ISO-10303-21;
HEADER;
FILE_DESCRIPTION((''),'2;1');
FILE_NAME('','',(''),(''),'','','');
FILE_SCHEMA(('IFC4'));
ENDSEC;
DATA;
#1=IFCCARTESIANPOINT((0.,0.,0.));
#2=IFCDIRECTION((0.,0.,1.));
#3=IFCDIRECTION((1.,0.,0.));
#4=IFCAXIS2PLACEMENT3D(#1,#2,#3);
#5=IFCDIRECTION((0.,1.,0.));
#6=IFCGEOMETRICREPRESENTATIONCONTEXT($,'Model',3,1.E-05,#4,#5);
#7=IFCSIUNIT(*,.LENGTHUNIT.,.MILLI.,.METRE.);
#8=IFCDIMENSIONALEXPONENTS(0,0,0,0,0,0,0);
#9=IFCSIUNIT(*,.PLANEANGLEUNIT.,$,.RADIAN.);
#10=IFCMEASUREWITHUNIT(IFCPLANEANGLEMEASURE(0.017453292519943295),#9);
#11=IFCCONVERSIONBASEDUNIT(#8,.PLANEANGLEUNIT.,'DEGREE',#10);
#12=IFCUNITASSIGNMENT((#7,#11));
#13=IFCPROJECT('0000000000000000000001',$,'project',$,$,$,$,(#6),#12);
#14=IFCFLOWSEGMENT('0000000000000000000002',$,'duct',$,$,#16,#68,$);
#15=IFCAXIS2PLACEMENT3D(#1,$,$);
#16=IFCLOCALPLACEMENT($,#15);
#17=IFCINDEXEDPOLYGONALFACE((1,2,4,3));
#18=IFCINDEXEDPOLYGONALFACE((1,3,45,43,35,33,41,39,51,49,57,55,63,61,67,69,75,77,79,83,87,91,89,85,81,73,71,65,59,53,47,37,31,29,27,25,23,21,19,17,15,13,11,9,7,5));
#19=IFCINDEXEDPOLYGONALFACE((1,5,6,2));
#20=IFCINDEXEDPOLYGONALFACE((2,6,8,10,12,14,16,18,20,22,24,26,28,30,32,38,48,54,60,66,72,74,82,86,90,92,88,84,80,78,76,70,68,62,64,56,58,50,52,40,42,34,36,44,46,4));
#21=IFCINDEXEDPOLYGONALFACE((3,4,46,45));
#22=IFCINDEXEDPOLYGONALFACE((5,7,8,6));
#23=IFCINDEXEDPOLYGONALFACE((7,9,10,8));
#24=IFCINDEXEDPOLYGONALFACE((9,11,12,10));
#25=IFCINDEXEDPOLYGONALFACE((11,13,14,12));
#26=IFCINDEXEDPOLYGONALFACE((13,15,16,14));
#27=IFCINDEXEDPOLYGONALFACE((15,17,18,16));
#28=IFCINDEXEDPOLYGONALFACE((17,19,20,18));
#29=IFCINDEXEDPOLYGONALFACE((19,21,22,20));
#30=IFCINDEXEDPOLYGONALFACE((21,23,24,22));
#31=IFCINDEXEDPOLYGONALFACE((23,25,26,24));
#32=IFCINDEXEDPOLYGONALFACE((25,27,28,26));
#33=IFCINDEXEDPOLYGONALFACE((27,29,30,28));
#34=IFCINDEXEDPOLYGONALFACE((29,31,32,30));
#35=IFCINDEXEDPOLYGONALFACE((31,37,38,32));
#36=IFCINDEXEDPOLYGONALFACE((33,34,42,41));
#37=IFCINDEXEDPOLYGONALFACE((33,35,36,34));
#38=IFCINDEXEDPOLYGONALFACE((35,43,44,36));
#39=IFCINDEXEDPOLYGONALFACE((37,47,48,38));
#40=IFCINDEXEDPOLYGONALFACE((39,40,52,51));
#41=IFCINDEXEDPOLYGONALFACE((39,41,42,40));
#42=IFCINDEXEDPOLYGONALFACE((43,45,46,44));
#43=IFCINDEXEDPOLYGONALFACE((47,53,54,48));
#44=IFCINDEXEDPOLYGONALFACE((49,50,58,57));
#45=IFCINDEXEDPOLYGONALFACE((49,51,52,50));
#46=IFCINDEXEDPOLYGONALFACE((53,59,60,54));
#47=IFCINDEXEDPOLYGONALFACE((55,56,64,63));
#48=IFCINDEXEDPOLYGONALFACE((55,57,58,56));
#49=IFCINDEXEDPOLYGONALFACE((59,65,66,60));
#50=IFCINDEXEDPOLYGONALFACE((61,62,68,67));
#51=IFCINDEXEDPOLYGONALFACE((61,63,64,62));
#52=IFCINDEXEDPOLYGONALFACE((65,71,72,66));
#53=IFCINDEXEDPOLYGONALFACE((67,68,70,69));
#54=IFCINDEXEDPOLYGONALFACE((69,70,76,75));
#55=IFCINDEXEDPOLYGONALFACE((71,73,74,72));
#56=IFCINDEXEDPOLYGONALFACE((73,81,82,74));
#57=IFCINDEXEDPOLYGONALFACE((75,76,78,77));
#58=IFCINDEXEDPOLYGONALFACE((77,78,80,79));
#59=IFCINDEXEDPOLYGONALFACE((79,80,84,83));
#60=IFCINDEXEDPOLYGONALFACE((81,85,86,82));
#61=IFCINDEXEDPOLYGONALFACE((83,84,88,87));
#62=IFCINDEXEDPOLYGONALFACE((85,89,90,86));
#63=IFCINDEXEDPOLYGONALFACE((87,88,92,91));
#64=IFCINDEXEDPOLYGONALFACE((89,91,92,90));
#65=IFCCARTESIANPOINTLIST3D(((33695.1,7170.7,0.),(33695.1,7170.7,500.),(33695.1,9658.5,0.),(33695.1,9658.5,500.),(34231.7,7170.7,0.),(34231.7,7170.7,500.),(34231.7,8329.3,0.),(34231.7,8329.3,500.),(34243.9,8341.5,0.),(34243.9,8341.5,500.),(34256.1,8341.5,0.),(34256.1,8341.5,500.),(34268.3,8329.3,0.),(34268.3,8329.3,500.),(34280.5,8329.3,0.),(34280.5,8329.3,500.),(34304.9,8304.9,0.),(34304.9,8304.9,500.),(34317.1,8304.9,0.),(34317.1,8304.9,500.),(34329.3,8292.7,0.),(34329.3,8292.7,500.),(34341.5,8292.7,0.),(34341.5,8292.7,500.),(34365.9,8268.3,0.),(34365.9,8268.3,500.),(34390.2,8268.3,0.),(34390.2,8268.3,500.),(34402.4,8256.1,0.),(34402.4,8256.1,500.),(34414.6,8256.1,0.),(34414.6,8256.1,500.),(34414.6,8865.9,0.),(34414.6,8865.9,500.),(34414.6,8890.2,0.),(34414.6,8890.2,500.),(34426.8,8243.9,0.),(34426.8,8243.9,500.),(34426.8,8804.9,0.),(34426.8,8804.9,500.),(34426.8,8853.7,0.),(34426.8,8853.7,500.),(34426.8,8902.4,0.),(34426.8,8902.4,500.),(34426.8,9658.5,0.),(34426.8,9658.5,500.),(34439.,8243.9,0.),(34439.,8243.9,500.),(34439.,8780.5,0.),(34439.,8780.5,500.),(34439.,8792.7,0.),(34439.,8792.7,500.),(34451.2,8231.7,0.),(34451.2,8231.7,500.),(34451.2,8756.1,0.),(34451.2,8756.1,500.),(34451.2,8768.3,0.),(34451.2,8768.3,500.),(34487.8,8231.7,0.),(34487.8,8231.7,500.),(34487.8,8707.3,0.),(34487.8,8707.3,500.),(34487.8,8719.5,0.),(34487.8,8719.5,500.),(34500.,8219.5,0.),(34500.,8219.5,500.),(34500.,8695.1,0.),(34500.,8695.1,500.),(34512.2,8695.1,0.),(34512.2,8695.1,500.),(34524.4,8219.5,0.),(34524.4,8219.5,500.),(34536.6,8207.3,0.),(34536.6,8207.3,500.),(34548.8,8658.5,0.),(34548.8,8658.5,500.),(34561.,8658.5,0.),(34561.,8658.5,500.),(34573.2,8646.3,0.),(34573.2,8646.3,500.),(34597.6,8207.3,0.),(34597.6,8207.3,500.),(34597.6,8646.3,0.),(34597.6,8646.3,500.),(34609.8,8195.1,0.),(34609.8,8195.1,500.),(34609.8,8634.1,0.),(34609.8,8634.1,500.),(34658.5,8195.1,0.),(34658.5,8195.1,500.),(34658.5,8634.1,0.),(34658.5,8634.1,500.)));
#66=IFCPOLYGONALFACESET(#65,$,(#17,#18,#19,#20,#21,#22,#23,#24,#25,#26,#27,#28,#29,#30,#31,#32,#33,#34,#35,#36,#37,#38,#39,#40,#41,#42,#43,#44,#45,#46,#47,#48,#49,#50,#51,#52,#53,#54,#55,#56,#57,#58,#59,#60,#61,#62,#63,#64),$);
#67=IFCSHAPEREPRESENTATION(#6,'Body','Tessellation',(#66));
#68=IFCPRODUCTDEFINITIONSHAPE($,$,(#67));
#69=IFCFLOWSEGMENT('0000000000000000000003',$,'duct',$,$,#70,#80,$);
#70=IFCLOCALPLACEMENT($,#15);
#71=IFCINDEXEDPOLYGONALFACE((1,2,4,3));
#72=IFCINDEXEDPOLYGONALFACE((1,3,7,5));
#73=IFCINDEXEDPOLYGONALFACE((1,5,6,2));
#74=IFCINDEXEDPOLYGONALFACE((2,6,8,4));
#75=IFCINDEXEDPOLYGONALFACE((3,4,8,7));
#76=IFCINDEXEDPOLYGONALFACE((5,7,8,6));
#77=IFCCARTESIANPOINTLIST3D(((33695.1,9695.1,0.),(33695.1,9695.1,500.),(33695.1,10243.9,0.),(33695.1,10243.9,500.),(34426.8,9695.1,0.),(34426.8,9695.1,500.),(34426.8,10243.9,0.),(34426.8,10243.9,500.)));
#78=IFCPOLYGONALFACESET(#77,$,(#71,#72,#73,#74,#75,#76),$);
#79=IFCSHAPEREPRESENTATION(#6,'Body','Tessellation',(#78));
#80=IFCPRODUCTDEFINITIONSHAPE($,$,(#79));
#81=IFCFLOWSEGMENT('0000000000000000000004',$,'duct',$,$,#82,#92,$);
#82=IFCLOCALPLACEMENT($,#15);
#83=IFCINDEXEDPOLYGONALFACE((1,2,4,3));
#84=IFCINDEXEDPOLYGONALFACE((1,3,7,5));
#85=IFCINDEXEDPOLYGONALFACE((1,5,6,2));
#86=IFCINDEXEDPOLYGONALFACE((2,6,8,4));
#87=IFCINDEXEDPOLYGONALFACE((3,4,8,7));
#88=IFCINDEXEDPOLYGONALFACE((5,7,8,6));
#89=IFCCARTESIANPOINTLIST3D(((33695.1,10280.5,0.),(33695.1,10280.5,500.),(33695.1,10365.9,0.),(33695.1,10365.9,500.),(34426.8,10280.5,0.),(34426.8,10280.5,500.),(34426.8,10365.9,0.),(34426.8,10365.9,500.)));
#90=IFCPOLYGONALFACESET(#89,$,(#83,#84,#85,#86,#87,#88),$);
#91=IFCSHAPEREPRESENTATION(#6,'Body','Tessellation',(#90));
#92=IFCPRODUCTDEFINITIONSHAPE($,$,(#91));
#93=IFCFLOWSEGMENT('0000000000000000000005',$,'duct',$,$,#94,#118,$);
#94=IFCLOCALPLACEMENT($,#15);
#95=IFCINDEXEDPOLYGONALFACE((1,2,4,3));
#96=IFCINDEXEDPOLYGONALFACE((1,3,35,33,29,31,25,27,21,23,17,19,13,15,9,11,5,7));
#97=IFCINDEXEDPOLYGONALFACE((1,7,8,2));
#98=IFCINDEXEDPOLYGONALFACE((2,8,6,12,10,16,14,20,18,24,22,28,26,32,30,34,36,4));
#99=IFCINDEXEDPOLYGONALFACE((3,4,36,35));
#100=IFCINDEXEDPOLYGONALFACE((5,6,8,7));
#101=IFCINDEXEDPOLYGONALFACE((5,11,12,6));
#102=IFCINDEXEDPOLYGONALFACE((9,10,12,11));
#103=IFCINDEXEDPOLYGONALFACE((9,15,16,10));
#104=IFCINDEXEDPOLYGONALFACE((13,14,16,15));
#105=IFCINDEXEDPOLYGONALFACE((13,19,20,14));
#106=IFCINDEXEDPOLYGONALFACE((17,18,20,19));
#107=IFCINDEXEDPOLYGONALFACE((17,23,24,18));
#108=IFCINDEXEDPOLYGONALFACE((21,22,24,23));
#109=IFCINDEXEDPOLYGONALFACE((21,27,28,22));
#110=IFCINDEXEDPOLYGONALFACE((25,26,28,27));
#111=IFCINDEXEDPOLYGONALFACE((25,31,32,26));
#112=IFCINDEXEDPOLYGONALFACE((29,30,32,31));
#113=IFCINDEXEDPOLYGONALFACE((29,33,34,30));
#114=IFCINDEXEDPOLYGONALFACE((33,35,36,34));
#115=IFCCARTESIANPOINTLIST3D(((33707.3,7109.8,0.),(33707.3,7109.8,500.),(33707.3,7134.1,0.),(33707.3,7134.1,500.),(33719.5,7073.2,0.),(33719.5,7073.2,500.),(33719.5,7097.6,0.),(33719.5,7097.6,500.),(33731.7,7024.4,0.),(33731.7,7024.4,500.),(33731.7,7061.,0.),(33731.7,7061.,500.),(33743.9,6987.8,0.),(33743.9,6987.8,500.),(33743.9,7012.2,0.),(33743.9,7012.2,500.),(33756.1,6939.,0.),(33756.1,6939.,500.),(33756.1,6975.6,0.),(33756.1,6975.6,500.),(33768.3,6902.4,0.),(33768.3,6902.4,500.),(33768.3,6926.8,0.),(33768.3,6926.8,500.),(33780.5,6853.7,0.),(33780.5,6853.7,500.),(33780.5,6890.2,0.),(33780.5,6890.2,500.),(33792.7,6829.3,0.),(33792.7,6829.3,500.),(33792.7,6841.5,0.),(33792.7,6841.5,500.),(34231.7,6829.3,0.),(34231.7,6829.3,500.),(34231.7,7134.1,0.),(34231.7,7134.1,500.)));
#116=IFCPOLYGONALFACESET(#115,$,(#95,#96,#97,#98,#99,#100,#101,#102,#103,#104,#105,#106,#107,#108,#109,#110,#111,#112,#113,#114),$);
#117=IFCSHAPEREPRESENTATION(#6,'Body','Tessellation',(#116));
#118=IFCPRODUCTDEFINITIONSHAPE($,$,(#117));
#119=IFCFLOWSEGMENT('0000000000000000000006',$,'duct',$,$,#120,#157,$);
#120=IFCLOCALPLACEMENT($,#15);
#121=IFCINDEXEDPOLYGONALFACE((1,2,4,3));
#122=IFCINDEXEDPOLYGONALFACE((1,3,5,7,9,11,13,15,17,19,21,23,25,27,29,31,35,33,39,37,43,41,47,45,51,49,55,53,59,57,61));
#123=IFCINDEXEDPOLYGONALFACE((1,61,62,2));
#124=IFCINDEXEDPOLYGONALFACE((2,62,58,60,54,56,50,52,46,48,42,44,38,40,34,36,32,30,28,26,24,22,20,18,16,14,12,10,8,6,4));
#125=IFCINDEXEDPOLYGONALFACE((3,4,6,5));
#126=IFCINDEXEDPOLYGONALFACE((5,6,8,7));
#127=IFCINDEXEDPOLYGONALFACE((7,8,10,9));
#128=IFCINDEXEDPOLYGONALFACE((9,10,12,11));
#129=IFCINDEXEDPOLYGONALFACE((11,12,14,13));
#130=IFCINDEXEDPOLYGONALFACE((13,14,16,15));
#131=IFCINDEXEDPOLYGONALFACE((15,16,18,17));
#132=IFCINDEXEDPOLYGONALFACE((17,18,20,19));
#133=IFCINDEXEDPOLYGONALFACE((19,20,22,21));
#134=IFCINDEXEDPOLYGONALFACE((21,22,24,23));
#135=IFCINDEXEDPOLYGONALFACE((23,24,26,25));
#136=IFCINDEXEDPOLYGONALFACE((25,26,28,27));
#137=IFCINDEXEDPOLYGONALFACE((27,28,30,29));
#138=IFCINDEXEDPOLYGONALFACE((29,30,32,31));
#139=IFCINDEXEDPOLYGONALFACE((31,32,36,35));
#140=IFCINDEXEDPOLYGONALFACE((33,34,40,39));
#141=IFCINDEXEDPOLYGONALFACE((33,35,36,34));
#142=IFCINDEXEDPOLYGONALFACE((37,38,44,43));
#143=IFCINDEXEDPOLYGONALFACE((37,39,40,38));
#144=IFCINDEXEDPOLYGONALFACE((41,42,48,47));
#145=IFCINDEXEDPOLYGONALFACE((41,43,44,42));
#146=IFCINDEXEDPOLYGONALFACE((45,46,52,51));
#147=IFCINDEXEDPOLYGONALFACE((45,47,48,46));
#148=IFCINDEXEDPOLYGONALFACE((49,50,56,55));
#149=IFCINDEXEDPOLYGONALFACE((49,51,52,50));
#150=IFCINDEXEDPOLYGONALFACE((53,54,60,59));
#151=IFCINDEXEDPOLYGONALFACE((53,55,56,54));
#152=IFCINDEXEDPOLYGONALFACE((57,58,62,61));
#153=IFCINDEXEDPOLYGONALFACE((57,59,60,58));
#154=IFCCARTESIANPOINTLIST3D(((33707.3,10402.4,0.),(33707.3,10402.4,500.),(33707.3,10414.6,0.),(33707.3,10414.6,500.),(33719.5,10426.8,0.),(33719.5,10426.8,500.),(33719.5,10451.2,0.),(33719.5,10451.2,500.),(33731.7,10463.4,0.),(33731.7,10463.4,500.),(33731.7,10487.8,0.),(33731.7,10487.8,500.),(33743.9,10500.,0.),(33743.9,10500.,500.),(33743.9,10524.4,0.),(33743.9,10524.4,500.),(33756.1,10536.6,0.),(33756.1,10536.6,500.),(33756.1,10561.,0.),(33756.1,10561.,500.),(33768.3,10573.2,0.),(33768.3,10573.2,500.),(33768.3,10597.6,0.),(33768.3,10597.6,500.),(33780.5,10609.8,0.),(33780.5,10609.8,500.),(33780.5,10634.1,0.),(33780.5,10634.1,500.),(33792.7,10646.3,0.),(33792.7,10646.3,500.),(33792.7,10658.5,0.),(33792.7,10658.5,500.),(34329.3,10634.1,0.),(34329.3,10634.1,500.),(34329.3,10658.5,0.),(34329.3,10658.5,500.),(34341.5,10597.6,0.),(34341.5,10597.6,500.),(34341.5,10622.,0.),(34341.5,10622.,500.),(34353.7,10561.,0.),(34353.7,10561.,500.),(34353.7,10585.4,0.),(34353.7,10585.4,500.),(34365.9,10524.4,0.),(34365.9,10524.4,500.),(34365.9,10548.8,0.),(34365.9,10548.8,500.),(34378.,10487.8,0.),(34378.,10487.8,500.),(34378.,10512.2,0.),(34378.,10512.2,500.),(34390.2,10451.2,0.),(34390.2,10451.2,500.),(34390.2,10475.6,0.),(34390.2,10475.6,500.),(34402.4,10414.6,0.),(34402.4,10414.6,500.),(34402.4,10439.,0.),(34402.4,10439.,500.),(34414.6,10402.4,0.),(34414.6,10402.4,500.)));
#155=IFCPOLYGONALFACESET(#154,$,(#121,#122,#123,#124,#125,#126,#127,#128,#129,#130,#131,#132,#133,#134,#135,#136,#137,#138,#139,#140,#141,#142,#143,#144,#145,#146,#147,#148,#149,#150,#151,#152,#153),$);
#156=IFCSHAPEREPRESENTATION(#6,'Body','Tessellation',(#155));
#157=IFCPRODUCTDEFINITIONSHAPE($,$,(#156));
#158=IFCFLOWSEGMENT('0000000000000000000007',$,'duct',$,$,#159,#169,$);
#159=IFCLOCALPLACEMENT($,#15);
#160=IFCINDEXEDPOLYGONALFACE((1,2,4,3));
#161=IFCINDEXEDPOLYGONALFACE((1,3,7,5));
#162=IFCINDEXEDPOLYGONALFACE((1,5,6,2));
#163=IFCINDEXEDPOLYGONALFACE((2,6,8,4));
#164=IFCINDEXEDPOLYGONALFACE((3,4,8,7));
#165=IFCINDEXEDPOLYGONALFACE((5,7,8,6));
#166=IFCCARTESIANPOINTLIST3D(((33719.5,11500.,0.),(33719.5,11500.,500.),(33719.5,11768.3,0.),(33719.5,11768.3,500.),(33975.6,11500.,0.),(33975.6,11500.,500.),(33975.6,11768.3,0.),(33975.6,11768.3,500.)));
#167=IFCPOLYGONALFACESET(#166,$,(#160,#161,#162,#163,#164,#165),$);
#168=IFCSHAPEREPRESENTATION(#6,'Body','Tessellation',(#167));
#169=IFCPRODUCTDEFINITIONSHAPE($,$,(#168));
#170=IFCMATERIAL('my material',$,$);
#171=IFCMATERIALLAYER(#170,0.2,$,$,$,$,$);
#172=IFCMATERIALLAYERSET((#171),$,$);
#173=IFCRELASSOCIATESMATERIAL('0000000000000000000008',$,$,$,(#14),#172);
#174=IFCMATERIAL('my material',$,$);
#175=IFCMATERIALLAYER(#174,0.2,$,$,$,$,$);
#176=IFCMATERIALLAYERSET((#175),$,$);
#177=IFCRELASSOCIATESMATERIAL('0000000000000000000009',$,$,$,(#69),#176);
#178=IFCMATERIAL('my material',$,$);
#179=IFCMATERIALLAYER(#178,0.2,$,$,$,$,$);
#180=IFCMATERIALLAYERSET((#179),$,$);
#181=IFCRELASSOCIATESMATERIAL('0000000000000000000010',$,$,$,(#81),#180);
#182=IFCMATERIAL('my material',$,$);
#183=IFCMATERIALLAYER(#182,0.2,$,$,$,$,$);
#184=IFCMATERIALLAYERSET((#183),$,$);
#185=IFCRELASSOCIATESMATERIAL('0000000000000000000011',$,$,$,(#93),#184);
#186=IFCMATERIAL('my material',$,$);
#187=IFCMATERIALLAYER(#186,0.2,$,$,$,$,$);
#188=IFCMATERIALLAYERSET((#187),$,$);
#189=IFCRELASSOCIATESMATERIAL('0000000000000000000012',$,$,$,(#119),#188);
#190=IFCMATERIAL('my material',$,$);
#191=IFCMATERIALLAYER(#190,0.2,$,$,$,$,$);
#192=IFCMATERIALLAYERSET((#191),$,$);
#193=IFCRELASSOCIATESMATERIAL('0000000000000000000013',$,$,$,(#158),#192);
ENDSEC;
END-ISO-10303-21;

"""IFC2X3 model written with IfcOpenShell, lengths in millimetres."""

from ifc_helpers import new_model, entity, si_unit, converted_unit, direction, origin_with_axes, place, context, project, polyline, outline, extrude, material, layer, layer_set, layer_usage, element, save


model = new_model("IFC2X3")

# Units and contexts
model_context = context("Model", 3, precision=1e-05, world=origin_with_axes(), true_north=direction((0.0, 1.0, 0.0)))
ifc_project = project(units=[si_unit("LENGTHUNIT", "METRE", prefix="MILLI"), converted_unit("PLANEANGLEUNIT", "DEGREE", entity("IfcPlaneAngleMeasure", 0.017453292519943295), si_unit("PLANEANGLEUNIT", "RADIAN"), dimensions=[0, 0, 0, 0, 0, 0, 0])], contexts=[model_context])

# Flow segments
ifc_material_1 = material(Name="my material")
ifc_layer_1 = layer(ifc_material_1, 0.2)
ifc_layer_set_1 = layer_set([ifc_layer_1])
ifc_layer_usage_1 = layer_usage(ifc_layer_set_1, "AXIS2", "POSITIVE", -0.1)
flow_segment_1_placement = place(None, origin_with_axes())
element("IfcFlowSegment", 1, at=flow_segment_1_placement, material=ifc_layer_usage_1, Name="duct", context=model_context, shape_type="SweptSolid", body=[
    extrude(outline(polyline([(33695.1, 7170.7), (34231.7, 7170.7), (34231.7, 8329.3), (34243.9, 8341.5), (34256.1, 8341.5), (34268.3, 8329.3), (34280.5, 8329.3), (34304.9, 8304.9), (34317.1, 8304.9), (34329.3, 8292.7), (34341.5, 8292.7), (34365.9, 8268.3), (34390.2, 8268.3), (34402.4, 8256.1), (34414.6, 8256.1), (34426.8, 8243.9), (34439.0, 8243.9), (34451.2, 8231.7), (34487.8, 8231.7), (34500.0, 8219.5), (34524.4, 8219.5), (34536.6, 8207.3), (34597.6, 8207.3), (34609.8, 8195.1), (34658.5, 8195.1), (34658.5, 8634.1), (34609.8, 8634.1), (34597.6, 8646.3), (34573.2, 8646.3), (34561.0, 8658.5), (34548.8, 8658.5), (34512.2, 8695.1), (34500.0, 8695.1), (34487.8, 8707.3), (34487.8, 8719.5), (34451.2, 8756.1), (34451.2, 8768.3), (34439.0, 8780.5), (34439.0, 8792.7), (34426.8, 8804.9), (34426.8, 8853.7), (34414.6, 8865.9), (34414.6, 8890.2), (34426.8, 8902.4), (34426.8, 9658.5), (33695.1, 9658.5), (33695.1, 7170.7)])), origin_with_axes(), (0.0, 0.0, 1.0), 500.0),
])
ifc_material_2 = material(Name="my material")
ifc_layer_2 = layer(ifc_material_2, 0.2)
ifc_layer_set_2 = layer_set([ifc_layer_2])
ifc_layer_usage_2 = layer_usage(ifc_layer_set_2, "AXIS2", "POSITIVE", -0.1)
flow_segment_2_placement = place(None, origin_with_axes())
element("IfcFlowSegment", 2, at=flow_segment_2_placement, material=ifc_layer_usage_2, Name="duct", context=model_context, shape_type="SweptSolid", body=[
    extrude(outline(polyline([(33695.1, 9695.1), (34426.8, 9695.1), (34426.8, 10243.9), (33695.1, 10243.9), (33695.1, 9695.1)])), origin_with_axes(), (0.0, 0.0, 1.0), 500.0),
])
ifc_material_3 = material(Name="my material")
ifc_layer_3 = layer(ifc_material_3, 0.2)
ifc_layer_set_3 = layer_set([ifc_layer_3])
ifc_layer_usage_3 = layer_usage(ifc_layer_set_3, "AXIS2", "POSITIVE", -0.1)
flow_segment_3_placement = place(None, origin_with_axes())
element("IfcFlowSegment", 3, at=flow_segment_3_placement, material=ifc_layer_usage_3, Name="duct", context=model_context, shape_type="SweptSolid", body=[
    extrude(outline(polyline([(33695.1, 10280.5), (34426.8, 10280.5), (34426.8, 10365.9), (33695.1, 10365.9), (33695.1, 10280.5)])), origin_with_axes(), (0.0, 0.0, 1.0), 500.0),
])
ifc_material_4 = material(Name="my material")
ifc_layer_4 = layer(ifc_material_4, 0.2)
ifc_layer_set_4 = layer_set([ifc_layer_4])
ifc_layer_usage_4 = layer_usage(ifc_layer_set_4, "AXIS2", "POSITIVE", -0.1)
flow_segment_4_placement = place(None, origin_with_axes())
element("IfcFlowSegment", 4, at=flow_segment_4_placement, material=ifc_layer_usage_4, Name="duct", context=model_context, shape_type="SweptSolid", body=[
    extrude(outline(polyline([(33707.3, 7109.8), (33719.5, 7097.6), (33719.5, 7073.2), (33731.7, 7061.0), (33731.7, 7024.4), (33743.9, 7012.2), (33743.9, 6987.8), (33756.1, 6975.6), (33756.1, 6939.0), (33768.3, 6926.8), (33768.3, 6902.4), (33780.5, 6890.2), (33780.5, 6853.7), (33792.7, 6841.5), (33792.7, 6829.3), (34231.7, 6829.3), (34231.7, 7134.1), (33707.3, 7134.1), (33707.3, 7109.8)])), origin_with_axes(), (0.0, 0.0, 1.0), 500.0),
])
ifc_material_5 = material(Name="my material")
ifc_layer_5 = layer(ifc_material_5, 0.2)
ifc_layer_set_5 = layer_set([ifc_layer_5])
ifc_layer_usage_5 = layer_usage(ifc_layer_set_5, "AXIS2", "POSITIVE", -0.1)
flow_segment_5_placement = place(None, origin_with_axes())
element("IfcFlowSegment", 5, at=flow_segment_5_placement, material=ifc_layer_usage_5, Name="duct", context=model_context, shape_type="SweptSolid", body=[
    extrude(outline(polyline([(33707.3, 10402.4), (34414.6, 10402.4), (34402.4, 10414.6), (34402.4, 10439.0), (34390.2, 10451.2), (34390.2, 10475.6), (34378.0, 10487.8), (34378.0, 10512.2), (34365.9, 10524.4), (34365.9, 10548.8), (34353.7, 10561.0), (34353.7, 10585.4), (34341.5, 10597.6), (34341.5, 10622.0), (34329.3, 10634.1), (34329.3, 10658.5), (33792.7, 10658.5), (33792.7, 10646.3), (33780.5, 10634.1), (33780.5, 10609.8), (33768.3, 10597.6), (33768.3, 10573.2), (33756.1, 10561.0), (33756.1, 10536.6), (33743.9, 10524.4), (33743.9, 10500.0), (33731.7, 10487.8), (33731.7, 10463.4), (33719.5, 10451.2), (33719.5, 10426.8), (33707.3, 10414.6), (33707.3, 10402.4)])), origin_with_axes(), (0.0, 0.0, 1.0), 500.0),
])
ifc_material_6 = material(Name="my material")
ifc_layer_6 = layer(ifc_material_6, 0.2)
ifc_layer_set_6 = layer_set([ifc_layer_6])
ifc_layer_usage_6 = layer_usage(ifc_layer_set_6, "AXIS2", "POSITIVE", -0.1)
flow_segment_6_placement = place(None, origin_with_axes())
element("IfcFlowSegment", 6, at=flow_segment_6_placement, material=ifc_layer_usage_6, Name="duct", context=model_context, shape_type="SweptSolid", body=[
    extrude(outline(polyline([(33719.5, 11500.0), (33975.6, 11500.0), (33975.6, 11768.3), (33719.5, 11768.3), (33719.5, 11500.0)])), origin_with_axes(), (0.0, 0.0, 1.0), 500.0),
])

save(model, "model.ifc")
